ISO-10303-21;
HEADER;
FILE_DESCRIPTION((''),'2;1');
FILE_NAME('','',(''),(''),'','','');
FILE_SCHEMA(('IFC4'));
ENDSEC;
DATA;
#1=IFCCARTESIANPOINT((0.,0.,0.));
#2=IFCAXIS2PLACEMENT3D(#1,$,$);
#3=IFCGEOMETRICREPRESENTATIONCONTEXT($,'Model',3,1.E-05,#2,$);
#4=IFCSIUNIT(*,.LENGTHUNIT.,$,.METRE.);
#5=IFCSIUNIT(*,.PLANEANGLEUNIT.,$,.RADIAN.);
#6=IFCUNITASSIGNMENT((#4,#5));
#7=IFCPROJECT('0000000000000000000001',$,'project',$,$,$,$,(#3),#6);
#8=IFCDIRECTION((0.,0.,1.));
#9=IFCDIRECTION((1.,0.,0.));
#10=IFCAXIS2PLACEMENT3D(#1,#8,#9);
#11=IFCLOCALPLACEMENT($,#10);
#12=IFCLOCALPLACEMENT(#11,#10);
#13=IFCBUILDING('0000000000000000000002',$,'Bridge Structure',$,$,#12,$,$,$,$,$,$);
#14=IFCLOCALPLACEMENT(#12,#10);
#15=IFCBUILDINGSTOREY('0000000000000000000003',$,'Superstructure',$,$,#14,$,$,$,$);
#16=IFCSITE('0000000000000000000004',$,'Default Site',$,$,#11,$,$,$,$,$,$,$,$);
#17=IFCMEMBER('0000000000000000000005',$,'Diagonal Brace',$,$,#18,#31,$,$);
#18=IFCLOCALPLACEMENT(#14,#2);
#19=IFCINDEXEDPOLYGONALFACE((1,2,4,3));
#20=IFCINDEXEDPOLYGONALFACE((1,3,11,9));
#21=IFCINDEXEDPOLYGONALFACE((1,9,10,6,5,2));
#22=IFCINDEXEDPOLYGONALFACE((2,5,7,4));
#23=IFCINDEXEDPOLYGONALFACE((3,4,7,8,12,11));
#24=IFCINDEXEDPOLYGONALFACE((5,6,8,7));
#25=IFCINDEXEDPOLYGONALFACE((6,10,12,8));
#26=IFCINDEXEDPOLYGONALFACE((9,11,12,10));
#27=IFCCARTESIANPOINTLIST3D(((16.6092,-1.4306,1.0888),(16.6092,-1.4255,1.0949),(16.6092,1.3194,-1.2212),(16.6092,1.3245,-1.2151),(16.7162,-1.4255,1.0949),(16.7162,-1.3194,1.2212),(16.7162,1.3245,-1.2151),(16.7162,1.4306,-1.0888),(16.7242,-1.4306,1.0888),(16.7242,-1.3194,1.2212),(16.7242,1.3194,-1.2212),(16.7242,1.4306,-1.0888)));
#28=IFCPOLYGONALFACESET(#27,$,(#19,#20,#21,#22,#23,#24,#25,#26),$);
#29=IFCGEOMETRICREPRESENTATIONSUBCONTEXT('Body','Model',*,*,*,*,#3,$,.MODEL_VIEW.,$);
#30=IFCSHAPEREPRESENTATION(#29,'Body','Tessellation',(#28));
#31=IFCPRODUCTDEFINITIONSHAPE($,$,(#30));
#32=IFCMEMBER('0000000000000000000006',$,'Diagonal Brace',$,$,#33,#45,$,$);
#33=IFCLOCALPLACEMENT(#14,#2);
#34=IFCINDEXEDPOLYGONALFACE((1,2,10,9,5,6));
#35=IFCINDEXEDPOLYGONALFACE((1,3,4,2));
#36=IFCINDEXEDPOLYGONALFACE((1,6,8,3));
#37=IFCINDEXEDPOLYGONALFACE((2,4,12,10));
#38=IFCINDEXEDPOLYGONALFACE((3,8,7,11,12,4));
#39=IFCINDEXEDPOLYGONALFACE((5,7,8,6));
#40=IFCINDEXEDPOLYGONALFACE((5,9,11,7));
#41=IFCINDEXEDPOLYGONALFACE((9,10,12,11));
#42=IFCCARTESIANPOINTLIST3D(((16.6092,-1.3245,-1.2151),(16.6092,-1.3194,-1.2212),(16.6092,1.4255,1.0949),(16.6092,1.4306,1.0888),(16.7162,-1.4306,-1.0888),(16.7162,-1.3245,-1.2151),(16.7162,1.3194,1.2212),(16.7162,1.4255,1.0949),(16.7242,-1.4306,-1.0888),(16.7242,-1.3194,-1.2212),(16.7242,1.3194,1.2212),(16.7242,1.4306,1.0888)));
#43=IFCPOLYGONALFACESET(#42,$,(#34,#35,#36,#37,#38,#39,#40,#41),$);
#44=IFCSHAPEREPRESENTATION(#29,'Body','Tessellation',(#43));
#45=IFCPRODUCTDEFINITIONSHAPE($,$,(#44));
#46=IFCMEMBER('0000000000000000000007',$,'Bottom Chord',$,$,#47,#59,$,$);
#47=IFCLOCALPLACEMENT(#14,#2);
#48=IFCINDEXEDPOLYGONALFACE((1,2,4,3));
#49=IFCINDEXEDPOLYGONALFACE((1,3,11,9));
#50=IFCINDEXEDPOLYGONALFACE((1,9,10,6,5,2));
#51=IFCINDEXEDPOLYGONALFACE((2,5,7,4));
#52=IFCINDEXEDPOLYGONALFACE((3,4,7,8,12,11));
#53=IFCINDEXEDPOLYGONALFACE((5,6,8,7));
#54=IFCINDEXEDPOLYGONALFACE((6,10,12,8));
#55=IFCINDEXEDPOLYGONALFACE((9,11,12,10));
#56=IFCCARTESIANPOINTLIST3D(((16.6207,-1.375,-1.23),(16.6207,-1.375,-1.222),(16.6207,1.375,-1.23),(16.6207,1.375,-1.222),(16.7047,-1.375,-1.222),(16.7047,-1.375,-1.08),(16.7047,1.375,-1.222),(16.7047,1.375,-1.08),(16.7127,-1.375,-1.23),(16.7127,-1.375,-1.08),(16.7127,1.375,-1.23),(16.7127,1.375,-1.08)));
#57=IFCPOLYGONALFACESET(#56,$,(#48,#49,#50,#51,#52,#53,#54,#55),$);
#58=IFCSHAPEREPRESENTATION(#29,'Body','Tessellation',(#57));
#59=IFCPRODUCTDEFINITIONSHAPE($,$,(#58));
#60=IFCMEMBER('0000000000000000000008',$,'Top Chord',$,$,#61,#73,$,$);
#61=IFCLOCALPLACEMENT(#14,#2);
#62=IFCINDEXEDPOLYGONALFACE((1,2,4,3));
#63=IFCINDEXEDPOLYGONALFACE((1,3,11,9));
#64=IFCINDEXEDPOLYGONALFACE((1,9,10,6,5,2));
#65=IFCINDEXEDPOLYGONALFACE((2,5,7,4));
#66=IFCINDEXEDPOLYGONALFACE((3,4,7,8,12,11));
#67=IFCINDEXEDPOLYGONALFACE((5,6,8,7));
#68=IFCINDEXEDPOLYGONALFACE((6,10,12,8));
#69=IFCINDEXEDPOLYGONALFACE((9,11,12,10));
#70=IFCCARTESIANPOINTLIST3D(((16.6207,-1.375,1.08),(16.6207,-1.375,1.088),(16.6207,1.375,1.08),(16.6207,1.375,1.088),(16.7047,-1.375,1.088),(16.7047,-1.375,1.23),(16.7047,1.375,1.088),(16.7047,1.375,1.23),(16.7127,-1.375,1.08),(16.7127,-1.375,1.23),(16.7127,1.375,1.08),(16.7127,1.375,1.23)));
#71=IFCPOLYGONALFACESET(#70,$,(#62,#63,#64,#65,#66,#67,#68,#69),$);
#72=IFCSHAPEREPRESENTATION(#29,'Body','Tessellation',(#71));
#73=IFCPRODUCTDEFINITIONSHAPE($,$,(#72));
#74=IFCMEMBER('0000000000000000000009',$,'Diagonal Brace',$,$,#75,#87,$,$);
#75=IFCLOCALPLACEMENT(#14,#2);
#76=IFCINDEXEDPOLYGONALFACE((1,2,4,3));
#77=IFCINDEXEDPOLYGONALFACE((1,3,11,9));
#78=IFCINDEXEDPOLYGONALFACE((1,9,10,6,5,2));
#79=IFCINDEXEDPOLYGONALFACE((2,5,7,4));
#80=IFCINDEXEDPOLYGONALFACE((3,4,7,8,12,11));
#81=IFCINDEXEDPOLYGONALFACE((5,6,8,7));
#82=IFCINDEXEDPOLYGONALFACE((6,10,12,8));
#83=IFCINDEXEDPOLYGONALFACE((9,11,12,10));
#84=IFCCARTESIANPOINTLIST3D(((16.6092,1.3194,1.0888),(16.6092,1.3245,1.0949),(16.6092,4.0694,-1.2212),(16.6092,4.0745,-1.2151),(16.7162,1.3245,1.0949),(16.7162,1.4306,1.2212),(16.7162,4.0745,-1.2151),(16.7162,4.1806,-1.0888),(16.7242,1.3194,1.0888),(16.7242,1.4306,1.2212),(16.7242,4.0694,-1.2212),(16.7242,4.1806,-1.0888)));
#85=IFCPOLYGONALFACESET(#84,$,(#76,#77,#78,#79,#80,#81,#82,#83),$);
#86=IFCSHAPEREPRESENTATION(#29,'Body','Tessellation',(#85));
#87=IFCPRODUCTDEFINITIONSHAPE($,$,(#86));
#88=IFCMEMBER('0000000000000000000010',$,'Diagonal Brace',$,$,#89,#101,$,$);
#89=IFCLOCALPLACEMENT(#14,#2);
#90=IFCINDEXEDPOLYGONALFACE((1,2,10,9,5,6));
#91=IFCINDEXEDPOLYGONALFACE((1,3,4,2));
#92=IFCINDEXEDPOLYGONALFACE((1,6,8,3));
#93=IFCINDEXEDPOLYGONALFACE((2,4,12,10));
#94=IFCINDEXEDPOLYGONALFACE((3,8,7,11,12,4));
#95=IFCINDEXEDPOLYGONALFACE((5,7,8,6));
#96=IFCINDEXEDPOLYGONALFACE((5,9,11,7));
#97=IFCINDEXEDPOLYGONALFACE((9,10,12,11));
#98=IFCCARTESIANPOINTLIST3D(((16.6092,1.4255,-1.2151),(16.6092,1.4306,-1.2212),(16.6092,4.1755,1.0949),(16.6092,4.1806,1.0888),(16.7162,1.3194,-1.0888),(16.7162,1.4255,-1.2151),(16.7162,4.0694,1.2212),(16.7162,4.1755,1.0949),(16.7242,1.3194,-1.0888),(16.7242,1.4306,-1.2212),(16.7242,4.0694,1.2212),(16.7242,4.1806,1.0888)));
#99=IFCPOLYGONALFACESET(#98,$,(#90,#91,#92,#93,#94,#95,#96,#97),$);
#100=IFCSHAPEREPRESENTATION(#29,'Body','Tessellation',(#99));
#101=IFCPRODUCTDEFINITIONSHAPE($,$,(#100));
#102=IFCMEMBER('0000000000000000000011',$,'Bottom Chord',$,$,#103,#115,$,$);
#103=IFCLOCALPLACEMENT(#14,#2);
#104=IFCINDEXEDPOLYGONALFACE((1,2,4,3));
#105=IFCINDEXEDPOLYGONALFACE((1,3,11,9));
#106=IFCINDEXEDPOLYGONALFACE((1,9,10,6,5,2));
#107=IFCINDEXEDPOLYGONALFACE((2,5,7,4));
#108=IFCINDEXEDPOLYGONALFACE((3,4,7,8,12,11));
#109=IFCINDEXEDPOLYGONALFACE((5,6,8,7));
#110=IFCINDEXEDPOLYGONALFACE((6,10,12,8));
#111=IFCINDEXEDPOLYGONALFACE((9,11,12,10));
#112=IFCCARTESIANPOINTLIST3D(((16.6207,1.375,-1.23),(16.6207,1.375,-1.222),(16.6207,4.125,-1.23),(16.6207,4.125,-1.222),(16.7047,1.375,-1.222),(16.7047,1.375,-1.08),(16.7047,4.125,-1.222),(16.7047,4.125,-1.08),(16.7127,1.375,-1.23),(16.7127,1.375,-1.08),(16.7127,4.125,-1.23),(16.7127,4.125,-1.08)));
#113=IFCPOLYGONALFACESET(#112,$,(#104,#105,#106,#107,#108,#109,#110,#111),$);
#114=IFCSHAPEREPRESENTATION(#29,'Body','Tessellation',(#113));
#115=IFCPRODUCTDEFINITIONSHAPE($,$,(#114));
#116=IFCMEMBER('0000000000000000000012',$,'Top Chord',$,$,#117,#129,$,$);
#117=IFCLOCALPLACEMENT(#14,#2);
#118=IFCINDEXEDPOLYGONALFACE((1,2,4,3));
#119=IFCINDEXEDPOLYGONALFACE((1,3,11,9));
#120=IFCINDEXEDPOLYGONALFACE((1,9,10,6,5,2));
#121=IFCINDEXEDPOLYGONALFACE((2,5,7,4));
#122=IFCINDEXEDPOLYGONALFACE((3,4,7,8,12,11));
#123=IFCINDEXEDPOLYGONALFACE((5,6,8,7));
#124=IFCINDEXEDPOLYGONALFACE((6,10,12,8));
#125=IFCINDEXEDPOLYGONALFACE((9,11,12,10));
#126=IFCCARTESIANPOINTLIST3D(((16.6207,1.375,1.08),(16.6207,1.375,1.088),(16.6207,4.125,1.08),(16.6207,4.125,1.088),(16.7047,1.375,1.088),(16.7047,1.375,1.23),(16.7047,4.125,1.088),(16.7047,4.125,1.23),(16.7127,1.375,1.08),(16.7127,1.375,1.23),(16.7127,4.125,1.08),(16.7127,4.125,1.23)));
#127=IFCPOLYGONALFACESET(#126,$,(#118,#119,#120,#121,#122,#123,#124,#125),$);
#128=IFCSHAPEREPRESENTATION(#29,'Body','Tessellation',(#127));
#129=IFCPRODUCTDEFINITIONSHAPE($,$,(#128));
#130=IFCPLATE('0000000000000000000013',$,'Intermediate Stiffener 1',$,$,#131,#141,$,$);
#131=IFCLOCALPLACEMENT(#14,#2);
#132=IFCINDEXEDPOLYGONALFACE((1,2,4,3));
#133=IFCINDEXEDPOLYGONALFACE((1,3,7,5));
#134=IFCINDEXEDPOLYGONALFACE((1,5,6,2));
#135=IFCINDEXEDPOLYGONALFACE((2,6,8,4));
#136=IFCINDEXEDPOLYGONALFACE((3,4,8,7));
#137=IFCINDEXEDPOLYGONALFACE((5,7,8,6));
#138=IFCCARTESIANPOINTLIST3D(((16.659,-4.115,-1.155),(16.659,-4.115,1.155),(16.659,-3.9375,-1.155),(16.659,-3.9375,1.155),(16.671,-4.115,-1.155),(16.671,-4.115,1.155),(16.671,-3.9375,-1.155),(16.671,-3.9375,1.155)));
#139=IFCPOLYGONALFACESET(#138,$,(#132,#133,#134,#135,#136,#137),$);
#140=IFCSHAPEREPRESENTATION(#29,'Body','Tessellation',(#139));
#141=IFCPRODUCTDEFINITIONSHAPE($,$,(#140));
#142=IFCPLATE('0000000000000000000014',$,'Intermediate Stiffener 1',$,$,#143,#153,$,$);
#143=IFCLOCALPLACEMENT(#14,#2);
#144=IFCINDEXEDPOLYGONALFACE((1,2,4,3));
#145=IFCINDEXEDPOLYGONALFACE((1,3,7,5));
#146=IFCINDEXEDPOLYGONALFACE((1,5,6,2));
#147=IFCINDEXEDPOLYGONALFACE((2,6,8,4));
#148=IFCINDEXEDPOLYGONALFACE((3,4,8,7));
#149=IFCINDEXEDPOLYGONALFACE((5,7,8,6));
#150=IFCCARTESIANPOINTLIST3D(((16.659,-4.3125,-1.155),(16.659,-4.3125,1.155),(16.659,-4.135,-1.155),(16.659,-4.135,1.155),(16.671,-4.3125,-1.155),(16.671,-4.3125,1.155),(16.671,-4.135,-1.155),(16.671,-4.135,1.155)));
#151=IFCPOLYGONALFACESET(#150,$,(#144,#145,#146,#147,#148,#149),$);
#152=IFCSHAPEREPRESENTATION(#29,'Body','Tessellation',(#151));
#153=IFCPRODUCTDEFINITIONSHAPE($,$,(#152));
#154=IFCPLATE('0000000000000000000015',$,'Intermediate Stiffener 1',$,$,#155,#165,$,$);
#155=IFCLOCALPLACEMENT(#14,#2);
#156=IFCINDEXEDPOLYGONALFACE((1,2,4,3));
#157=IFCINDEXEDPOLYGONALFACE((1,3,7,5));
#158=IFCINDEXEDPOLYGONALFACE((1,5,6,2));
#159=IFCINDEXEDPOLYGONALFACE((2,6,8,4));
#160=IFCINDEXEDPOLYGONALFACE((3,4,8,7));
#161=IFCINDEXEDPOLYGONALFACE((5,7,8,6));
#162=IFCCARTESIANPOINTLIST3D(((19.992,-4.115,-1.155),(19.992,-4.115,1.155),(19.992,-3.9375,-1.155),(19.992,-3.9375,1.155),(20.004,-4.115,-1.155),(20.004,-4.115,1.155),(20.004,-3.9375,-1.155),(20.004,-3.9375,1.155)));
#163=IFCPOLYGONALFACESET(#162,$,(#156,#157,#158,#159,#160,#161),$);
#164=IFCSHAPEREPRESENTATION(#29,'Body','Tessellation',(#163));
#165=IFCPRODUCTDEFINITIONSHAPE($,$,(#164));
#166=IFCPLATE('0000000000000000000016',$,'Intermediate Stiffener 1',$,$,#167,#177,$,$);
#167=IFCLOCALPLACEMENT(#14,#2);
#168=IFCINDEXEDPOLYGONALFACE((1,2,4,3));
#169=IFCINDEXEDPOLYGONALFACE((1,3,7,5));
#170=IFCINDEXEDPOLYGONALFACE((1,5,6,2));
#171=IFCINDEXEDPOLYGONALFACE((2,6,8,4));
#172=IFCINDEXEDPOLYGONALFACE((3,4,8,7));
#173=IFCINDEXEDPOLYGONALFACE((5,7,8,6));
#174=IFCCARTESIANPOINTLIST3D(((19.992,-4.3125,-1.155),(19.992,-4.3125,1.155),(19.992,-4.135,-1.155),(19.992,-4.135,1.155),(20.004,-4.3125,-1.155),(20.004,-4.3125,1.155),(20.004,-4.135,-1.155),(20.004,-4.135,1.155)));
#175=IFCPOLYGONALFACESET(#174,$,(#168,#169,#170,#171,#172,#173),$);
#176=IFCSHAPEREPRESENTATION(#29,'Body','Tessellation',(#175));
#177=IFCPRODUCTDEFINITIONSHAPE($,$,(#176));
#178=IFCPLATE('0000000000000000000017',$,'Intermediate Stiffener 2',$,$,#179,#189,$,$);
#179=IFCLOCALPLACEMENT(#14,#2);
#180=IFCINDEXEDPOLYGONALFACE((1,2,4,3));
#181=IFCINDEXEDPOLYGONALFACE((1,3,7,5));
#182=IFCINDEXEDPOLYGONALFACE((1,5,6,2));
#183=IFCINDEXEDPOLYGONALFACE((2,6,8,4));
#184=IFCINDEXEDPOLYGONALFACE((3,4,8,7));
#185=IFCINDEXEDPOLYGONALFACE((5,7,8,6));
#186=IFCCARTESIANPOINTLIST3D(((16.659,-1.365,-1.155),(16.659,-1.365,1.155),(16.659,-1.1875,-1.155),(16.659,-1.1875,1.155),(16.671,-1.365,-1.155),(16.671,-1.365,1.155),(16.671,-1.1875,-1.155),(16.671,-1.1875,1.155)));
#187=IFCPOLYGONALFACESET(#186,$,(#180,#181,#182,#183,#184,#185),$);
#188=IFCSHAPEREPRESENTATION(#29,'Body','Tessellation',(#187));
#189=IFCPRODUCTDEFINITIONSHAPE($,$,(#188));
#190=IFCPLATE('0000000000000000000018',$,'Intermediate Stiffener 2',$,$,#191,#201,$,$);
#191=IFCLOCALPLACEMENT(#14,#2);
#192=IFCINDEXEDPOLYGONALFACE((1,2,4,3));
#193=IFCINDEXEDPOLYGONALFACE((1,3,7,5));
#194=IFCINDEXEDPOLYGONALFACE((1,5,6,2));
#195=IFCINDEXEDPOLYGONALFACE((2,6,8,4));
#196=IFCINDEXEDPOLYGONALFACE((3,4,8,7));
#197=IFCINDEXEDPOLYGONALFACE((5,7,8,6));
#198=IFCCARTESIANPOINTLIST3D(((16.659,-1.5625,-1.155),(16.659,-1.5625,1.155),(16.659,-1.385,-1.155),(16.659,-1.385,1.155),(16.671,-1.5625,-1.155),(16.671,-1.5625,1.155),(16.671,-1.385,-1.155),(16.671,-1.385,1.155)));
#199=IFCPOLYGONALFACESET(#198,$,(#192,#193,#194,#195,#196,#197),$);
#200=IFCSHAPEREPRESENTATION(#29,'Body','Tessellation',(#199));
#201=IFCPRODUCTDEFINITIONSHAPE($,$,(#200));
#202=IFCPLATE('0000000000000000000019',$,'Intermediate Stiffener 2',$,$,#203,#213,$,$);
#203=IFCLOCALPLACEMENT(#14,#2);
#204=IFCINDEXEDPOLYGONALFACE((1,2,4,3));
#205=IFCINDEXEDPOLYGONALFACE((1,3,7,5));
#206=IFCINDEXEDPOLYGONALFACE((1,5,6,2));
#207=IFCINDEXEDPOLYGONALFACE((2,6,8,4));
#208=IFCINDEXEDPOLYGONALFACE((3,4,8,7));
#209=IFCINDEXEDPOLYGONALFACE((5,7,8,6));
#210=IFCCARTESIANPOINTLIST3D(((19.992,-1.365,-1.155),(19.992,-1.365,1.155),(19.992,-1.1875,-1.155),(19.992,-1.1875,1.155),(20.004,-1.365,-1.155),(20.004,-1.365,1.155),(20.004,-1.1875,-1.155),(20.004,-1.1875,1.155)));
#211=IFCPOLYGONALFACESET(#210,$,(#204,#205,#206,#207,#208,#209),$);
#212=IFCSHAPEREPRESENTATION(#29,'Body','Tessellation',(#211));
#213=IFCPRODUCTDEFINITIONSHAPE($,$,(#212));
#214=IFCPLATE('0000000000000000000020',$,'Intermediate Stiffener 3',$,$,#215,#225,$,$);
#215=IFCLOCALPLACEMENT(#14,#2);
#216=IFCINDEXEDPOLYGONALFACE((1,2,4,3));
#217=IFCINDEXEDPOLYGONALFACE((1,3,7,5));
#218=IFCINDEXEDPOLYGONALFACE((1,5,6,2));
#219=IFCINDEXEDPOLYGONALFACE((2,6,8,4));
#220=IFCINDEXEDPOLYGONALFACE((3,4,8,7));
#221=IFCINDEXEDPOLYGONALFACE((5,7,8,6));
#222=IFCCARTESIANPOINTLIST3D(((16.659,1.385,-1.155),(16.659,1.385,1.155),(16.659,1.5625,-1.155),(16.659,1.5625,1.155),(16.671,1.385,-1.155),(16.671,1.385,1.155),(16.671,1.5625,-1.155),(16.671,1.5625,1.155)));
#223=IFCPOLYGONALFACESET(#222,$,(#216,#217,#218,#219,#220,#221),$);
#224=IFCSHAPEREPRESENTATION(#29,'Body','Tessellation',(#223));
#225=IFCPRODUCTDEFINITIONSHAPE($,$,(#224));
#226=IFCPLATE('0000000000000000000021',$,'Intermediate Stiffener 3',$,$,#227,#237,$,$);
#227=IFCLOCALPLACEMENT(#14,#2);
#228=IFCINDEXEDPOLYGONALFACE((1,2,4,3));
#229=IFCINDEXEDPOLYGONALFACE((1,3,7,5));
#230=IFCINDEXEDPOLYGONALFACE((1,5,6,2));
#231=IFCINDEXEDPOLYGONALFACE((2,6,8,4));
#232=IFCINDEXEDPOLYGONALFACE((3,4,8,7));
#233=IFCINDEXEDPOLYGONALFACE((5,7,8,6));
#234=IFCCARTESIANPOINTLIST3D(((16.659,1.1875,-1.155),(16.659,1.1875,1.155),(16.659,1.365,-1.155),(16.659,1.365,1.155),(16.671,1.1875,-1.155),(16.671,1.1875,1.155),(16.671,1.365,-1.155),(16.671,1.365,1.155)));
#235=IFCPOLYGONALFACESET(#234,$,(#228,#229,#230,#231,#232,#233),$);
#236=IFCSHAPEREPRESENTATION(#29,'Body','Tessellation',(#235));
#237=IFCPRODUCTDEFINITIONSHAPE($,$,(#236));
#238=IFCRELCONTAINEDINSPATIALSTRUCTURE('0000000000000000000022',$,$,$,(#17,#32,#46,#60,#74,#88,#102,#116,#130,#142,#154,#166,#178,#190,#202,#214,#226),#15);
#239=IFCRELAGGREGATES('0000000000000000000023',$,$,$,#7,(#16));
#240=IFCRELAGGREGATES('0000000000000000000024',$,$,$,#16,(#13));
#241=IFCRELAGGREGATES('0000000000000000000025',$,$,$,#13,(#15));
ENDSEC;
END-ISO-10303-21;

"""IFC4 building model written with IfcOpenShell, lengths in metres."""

from ifc_helpers import new_model, si_unit, frame, origin, origin_with_axes, origin_2d_with_axis, place, context, subcontext, project, spatial, rectangle, l_section, extrude, element, save


model = new_model("IFC4")

# Units and contexts
model_context = context("Model", 3, precision=1e-05, world=origin())
body_context = subcontext(model_context, "Body", "Model", "MODEL_VIEW")
ifc_project = project(units=[si_unit("LENGTHUNIT", "METRE"), si_unit("PLANEANGLEUNIT", "RADIAN")], contexts=[model_context])

# Site, building, storey
site_placement = place(None, origin_with_axes())
site = spatial("IfcSite", under=ifc_project, at=site_placement, Name="Default Site")
building_placement = place(site_placement, origin_with_axes())
building = spatial("IfcBuilding", under=site, at=building_placement, Name="Bridge Structure")
storey_placement = place(building_placement, origin_with_axes())
storey = spatial("IfcBuildingStorey", under=building, at=storey_placement, Name="Superstructure")

# Members
for number, where, z_axis, x_axis, name in (
    (1, (16.6667, -1.375, 1.155), (0.0, 0.765705, -0.643192), (-1.0, 0.0, 0.0), "Diagonal Brace"),
    (2, (16.6667, -1.375, -1.155), (0.0, 0.765705, 0.643192), (-1.0, 0.0, 0.0), "Diagonal Brace"),
):
    element("IfcMember", number, at=place(storey_placement, frame(where, z_axis=z_axis, x_axis=x_axis)), inside=storey, Name=name, context=body_context, shape_type="SweptSolid", body=[
        extrude(l_section(Depth=0.173, Width=0.115, Thickness=0.008, at=origin_2d_with_axis()), origin_with_axes(), (0.0, 0.0, 1.0), 3.5915),
    ])
for number, where, z_axis, x_axis, name in (
    (3, (16.6667, -1.375, -1.155), (0.0, 1.0, 0.0), (-1.0, 0.0, 0.0), "Bottom Chord"),
    (4, (16.6667, -1.375, 1.155), (0.0, 1.0, 0.0), (-1.0, 0.0, 0.0), "Top Chord"),
):
    element("IfcMember", number, at=place(storey_placement, frame(where, z_axis=z_axis, x_axis=x_axis)), inside=storey, Name=name, context=body_context, shape_type="SweptSolid", body=[
        extrude(l_section(Depth=0.15, Width=0.092, Thickness=0.008, at=origin_2d_with_axis()), origin_with_axes(), (0.0, 0.0, 1.0), 2.75),
    ])
for number, where, z_axis, x_axis, name in (
    (5, (16.6667, 1.375, 1.155), (0.0, 0.765705, -0.643192), (-1.0, 0.0, 0.0), "Diagonal Brace"),
    (6, (16.6667, 1.375, -1.155), (0.0, 0.765705, 0.643192), (-1.0, 0.0, 0.0), "Diagonal Brace"),
):
    element("IfcMember", number, at=place(storey_placement, frame(where, z_axis=z_axis, x_axis=x_axis)), inside=storey, Name=name, context=body_context, shape_type="SweptSolid", body=[
        extrude(l_section(Depth=0.173, Width=0.115, Thickness=0.008, at=origin_2d_with_axis()), origin_with_axes(), (0.0, 0.0, 1.0), 3.5915),
    ])
for number, where, z_axis, x_axis, name in (
    (7, (16.6667, 1.375, -1.155), (0.0, 1.0, 0.0), (-1.0, 0.0, 0.0), "Bottom Chord"),
    (8, (16.6667, 1.375, 1.155), (0.0, 1.0, 0.0), (-1.0, 0.0, 0.0), "Top Chord"),
):
    element("IfcMember", number, at=place(storey_placement, frame(where, z_axis=z_axis, x_axis=x_axis)), inside=storey, Name=name, context=body_context, shape_type="SweptSolid", body=[
        extrude(l_section(Depth=0.15, Width=0.092, Thickness=0.008, at=origin_2d_with_axis()), origin_with_axes(), (0.0, 0.0, 1.0), 2.75),
    ])

# Plates
for number, where, z_axis, x_axis, name in (
    (9, (16.665, -4.0263, -1.155), (0.0, 0.0, 1.0), (1.0, 0.0, 0.0), "Intermediate Stiffener 1"),
    (10, (16.665, -4.2237, -1.155), (0.0, 0.0, 1.0), (1.0, 0.0, 0.0), "Intermediate Stiffener 1"),
    (11, (19.998, -4.0263, -1.155), (0.0, 0.0, 1.0), (1.0, 0.0, 0.0), "Intermediate Stiffener 1"),
    (12, (19.998, -4.2237, -1.155), (0.0, 0.0, 1.0), (1.0, 0.0, 0.0), "Intermediate Stiffener 1"),
    (13, (16.665, -1.2763, -1.155), (0.0, 0.0, 1.0), (1.0, 0.0, 0.0), "Intermediate Stiffener 2"),
    (14, (16.665, -1.4738, -1.155), (0.0, 0.0, 1.0), (1.0, 0.0, 0.0), "Intermediate Stiffener 2"),
    (15, (19.998, -1.2763, -1.155), (0.0, 0.0, 1.0), (1.0, 0.0, 0.0), "Intermediate Stiffener 2"),
    (16, (16.665, 1.4738, -1.155), (0.0, 0.0, 1.0), (1.0, 0.0, 0.0), "Intermediate Stiffener 3"),
    (17, (16.665, 1.2763, -1.155), (0.0, 0.0, 1.0), (1.0, 0.0, 0.0), "Intermediate Stiffener 3"),
):
    element("IfcPlate", number, at=place(storey_placement, frame(where, z_axis=z_axis, x_axis=x_axis)), inside=storey, Name=name, context=body_context, shape_type="SweptSolid", body=[
        extrude(rectangle(XDim=0.012, YDim=0.1775, at=origin_2d_with_axis()), origin_with_axes(), (0.0, 0.0, 1.0), 2.31),
    ])

save(model, "model.ifc")
